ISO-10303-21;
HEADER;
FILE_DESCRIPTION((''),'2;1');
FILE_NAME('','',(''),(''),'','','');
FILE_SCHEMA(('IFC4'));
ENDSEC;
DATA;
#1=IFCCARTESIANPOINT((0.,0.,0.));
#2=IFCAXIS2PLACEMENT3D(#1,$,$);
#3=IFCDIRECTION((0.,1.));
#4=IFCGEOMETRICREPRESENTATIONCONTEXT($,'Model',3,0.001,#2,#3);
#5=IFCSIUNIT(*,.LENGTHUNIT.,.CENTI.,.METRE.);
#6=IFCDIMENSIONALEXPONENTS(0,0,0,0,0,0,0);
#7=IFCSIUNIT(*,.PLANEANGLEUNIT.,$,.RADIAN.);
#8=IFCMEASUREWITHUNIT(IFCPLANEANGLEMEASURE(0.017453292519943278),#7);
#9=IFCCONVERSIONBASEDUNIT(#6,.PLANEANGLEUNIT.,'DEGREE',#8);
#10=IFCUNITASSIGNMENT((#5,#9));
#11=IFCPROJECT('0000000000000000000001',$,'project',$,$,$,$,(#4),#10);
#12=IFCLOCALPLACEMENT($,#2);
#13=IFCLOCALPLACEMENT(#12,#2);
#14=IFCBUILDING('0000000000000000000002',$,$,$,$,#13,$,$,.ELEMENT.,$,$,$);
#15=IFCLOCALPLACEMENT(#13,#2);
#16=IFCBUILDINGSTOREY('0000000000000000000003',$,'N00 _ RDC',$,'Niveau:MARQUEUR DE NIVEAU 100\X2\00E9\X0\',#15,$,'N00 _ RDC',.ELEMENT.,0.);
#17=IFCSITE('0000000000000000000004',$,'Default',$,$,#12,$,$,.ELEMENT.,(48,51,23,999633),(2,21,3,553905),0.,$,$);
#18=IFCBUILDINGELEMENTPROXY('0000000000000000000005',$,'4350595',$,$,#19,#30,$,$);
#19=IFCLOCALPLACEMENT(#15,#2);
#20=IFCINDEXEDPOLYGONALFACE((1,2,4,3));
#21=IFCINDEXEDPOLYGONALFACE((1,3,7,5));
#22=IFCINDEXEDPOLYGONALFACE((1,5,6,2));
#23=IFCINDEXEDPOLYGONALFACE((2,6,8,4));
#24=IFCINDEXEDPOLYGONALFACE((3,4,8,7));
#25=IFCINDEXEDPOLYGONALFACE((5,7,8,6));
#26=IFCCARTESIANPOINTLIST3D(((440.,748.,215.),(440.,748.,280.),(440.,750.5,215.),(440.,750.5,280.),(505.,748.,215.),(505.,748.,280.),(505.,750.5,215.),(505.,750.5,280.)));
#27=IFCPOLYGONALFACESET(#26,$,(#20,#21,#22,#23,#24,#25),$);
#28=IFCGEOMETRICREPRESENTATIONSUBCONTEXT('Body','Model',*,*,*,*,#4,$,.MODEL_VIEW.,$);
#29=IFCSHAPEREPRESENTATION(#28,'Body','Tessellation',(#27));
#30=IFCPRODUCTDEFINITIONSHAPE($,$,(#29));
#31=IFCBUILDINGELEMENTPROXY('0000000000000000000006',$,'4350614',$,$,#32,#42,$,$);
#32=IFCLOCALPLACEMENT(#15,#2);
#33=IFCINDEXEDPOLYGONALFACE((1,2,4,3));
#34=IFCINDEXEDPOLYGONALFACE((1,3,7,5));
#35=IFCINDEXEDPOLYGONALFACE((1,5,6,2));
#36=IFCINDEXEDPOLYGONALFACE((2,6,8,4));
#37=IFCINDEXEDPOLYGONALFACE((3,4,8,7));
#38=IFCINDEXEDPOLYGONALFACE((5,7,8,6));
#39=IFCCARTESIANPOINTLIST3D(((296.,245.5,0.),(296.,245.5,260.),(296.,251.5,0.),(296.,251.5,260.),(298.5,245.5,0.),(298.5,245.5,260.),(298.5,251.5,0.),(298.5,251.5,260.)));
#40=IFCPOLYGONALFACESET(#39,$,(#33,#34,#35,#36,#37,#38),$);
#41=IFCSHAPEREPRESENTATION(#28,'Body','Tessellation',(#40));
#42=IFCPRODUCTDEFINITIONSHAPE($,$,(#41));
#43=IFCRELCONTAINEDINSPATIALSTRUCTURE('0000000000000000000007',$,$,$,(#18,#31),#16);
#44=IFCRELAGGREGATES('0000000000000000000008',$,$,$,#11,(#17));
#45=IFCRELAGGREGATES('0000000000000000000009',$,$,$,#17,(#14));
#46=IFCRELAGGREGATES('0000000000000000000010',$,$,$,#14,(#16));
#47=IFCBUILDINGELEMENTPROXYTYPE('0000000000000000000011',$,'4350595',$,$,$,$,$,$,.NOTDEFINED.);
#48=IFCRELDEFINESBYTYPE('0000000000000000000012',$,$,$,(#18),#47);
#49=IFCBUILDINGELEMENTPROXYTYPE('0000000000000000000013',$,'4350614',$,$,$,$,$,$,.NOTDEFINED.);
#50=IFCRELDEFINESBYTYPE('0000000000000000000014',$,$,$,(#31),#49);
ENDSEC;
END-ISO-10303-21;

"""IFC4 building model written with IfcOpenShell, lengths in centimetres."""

from ifc_helpers import new_model, entity, si_unit, converted_unit, direction, frame, frame_2d, origin, place, context, subcontext, project, spatial, rectangle, extrude, type_object, element, save


model = new_model("IFC4")

# Units and contexts
model_context = context("Model", 3, precision=0.001, world=origin(), true_north=direction((0.0, 1.0)))
body_context = subcontext(model_context, "Body", "Model", "MODEL_VIEW")
ifc_project = project(units=[si_unit("LENGTHUNIT", "METRE", prefix="CENTI"), converted_unit("PLANEANGLEUNIT", "DEGREE", entity("IfcPlaneAngleMeasure", 0.017453292519943278), si_unit("PLANEANGLEUNIT", "RADIAN"), dimensions=[0, 0, 0, 0, 0, 0, 0])], contexts=[model_context])

# Site, building, storey
site_placement = place(None, origin())
site = spatial("IfcSite", under=ifc_project, at=site_placement, Name="Default", CompositionType="ELEMENT", RefLatitude=(48, 51, 23, 999633), RefLongitude=(2, 21, 3, 553905), RefElevation=0.0)
building_placement = place(site_placement, origin())
building = spatial("IfcBuilding", under=site, at=building_placement, CompositionType="ELEMENT")
storey_placement = place(building_placement, origin())
storey = spatial("IfcBuildingStorey", under=building, at=storey_placement, Name="N00 _ RDC", ObjectType="Niveau:MARQUEUR DE NIVEAU 100é", LongName="N00 _ RDC", CompositionType="ELEMENT", Elevation=0.0)

# Building element proxies
building_element_proxy_type_1 = type_object("IfcBuildingElementProxyType", Name="4350595", PredefinedType="NOTDEFINED")
proxy_1_placement = place(storey_placement, origin())
element("IfcBuildingElementProxy", 1, at=proxy_1_placement, inside=storey, type_object=building_element_proxy_type_1, Name="4350595", context=body_context, shape_type="SweptSolid", body=[
    extrude(rectangle(XDim=65.0, YDim=2.5, at=frame_2d((0.0, 0.0), x_axis=(1.0, 0.0))), frame((472.5, 749.25, 215.0)), (0.0, 0.0, 1.0), 65.0),
])
building_element_proxy_type_2 = type_object("IfcBuildingElementProxyType", Name="4350614", PredefinedType="NOTDEFINED")
proxy_2_placement = place(storey_placement, origin())
element("IfcBuildingElementProxy", 2, at=proxy_2_placement, inside=storey, type_object=building_element_proxy_type_2, Name="4350614", context=body_context, shape_type="SweptSolid", body=[
    extrude(rectangle(XDim=2.5, YDim=6.0, at=frame_2d((0.0, 0.0), x_axis=(1.0, 0.0))), frame((297.25, 248.5, 0.0)), (0.0, 0.0, 1.0), 260.0),
])

save(model, "model.ifc")
